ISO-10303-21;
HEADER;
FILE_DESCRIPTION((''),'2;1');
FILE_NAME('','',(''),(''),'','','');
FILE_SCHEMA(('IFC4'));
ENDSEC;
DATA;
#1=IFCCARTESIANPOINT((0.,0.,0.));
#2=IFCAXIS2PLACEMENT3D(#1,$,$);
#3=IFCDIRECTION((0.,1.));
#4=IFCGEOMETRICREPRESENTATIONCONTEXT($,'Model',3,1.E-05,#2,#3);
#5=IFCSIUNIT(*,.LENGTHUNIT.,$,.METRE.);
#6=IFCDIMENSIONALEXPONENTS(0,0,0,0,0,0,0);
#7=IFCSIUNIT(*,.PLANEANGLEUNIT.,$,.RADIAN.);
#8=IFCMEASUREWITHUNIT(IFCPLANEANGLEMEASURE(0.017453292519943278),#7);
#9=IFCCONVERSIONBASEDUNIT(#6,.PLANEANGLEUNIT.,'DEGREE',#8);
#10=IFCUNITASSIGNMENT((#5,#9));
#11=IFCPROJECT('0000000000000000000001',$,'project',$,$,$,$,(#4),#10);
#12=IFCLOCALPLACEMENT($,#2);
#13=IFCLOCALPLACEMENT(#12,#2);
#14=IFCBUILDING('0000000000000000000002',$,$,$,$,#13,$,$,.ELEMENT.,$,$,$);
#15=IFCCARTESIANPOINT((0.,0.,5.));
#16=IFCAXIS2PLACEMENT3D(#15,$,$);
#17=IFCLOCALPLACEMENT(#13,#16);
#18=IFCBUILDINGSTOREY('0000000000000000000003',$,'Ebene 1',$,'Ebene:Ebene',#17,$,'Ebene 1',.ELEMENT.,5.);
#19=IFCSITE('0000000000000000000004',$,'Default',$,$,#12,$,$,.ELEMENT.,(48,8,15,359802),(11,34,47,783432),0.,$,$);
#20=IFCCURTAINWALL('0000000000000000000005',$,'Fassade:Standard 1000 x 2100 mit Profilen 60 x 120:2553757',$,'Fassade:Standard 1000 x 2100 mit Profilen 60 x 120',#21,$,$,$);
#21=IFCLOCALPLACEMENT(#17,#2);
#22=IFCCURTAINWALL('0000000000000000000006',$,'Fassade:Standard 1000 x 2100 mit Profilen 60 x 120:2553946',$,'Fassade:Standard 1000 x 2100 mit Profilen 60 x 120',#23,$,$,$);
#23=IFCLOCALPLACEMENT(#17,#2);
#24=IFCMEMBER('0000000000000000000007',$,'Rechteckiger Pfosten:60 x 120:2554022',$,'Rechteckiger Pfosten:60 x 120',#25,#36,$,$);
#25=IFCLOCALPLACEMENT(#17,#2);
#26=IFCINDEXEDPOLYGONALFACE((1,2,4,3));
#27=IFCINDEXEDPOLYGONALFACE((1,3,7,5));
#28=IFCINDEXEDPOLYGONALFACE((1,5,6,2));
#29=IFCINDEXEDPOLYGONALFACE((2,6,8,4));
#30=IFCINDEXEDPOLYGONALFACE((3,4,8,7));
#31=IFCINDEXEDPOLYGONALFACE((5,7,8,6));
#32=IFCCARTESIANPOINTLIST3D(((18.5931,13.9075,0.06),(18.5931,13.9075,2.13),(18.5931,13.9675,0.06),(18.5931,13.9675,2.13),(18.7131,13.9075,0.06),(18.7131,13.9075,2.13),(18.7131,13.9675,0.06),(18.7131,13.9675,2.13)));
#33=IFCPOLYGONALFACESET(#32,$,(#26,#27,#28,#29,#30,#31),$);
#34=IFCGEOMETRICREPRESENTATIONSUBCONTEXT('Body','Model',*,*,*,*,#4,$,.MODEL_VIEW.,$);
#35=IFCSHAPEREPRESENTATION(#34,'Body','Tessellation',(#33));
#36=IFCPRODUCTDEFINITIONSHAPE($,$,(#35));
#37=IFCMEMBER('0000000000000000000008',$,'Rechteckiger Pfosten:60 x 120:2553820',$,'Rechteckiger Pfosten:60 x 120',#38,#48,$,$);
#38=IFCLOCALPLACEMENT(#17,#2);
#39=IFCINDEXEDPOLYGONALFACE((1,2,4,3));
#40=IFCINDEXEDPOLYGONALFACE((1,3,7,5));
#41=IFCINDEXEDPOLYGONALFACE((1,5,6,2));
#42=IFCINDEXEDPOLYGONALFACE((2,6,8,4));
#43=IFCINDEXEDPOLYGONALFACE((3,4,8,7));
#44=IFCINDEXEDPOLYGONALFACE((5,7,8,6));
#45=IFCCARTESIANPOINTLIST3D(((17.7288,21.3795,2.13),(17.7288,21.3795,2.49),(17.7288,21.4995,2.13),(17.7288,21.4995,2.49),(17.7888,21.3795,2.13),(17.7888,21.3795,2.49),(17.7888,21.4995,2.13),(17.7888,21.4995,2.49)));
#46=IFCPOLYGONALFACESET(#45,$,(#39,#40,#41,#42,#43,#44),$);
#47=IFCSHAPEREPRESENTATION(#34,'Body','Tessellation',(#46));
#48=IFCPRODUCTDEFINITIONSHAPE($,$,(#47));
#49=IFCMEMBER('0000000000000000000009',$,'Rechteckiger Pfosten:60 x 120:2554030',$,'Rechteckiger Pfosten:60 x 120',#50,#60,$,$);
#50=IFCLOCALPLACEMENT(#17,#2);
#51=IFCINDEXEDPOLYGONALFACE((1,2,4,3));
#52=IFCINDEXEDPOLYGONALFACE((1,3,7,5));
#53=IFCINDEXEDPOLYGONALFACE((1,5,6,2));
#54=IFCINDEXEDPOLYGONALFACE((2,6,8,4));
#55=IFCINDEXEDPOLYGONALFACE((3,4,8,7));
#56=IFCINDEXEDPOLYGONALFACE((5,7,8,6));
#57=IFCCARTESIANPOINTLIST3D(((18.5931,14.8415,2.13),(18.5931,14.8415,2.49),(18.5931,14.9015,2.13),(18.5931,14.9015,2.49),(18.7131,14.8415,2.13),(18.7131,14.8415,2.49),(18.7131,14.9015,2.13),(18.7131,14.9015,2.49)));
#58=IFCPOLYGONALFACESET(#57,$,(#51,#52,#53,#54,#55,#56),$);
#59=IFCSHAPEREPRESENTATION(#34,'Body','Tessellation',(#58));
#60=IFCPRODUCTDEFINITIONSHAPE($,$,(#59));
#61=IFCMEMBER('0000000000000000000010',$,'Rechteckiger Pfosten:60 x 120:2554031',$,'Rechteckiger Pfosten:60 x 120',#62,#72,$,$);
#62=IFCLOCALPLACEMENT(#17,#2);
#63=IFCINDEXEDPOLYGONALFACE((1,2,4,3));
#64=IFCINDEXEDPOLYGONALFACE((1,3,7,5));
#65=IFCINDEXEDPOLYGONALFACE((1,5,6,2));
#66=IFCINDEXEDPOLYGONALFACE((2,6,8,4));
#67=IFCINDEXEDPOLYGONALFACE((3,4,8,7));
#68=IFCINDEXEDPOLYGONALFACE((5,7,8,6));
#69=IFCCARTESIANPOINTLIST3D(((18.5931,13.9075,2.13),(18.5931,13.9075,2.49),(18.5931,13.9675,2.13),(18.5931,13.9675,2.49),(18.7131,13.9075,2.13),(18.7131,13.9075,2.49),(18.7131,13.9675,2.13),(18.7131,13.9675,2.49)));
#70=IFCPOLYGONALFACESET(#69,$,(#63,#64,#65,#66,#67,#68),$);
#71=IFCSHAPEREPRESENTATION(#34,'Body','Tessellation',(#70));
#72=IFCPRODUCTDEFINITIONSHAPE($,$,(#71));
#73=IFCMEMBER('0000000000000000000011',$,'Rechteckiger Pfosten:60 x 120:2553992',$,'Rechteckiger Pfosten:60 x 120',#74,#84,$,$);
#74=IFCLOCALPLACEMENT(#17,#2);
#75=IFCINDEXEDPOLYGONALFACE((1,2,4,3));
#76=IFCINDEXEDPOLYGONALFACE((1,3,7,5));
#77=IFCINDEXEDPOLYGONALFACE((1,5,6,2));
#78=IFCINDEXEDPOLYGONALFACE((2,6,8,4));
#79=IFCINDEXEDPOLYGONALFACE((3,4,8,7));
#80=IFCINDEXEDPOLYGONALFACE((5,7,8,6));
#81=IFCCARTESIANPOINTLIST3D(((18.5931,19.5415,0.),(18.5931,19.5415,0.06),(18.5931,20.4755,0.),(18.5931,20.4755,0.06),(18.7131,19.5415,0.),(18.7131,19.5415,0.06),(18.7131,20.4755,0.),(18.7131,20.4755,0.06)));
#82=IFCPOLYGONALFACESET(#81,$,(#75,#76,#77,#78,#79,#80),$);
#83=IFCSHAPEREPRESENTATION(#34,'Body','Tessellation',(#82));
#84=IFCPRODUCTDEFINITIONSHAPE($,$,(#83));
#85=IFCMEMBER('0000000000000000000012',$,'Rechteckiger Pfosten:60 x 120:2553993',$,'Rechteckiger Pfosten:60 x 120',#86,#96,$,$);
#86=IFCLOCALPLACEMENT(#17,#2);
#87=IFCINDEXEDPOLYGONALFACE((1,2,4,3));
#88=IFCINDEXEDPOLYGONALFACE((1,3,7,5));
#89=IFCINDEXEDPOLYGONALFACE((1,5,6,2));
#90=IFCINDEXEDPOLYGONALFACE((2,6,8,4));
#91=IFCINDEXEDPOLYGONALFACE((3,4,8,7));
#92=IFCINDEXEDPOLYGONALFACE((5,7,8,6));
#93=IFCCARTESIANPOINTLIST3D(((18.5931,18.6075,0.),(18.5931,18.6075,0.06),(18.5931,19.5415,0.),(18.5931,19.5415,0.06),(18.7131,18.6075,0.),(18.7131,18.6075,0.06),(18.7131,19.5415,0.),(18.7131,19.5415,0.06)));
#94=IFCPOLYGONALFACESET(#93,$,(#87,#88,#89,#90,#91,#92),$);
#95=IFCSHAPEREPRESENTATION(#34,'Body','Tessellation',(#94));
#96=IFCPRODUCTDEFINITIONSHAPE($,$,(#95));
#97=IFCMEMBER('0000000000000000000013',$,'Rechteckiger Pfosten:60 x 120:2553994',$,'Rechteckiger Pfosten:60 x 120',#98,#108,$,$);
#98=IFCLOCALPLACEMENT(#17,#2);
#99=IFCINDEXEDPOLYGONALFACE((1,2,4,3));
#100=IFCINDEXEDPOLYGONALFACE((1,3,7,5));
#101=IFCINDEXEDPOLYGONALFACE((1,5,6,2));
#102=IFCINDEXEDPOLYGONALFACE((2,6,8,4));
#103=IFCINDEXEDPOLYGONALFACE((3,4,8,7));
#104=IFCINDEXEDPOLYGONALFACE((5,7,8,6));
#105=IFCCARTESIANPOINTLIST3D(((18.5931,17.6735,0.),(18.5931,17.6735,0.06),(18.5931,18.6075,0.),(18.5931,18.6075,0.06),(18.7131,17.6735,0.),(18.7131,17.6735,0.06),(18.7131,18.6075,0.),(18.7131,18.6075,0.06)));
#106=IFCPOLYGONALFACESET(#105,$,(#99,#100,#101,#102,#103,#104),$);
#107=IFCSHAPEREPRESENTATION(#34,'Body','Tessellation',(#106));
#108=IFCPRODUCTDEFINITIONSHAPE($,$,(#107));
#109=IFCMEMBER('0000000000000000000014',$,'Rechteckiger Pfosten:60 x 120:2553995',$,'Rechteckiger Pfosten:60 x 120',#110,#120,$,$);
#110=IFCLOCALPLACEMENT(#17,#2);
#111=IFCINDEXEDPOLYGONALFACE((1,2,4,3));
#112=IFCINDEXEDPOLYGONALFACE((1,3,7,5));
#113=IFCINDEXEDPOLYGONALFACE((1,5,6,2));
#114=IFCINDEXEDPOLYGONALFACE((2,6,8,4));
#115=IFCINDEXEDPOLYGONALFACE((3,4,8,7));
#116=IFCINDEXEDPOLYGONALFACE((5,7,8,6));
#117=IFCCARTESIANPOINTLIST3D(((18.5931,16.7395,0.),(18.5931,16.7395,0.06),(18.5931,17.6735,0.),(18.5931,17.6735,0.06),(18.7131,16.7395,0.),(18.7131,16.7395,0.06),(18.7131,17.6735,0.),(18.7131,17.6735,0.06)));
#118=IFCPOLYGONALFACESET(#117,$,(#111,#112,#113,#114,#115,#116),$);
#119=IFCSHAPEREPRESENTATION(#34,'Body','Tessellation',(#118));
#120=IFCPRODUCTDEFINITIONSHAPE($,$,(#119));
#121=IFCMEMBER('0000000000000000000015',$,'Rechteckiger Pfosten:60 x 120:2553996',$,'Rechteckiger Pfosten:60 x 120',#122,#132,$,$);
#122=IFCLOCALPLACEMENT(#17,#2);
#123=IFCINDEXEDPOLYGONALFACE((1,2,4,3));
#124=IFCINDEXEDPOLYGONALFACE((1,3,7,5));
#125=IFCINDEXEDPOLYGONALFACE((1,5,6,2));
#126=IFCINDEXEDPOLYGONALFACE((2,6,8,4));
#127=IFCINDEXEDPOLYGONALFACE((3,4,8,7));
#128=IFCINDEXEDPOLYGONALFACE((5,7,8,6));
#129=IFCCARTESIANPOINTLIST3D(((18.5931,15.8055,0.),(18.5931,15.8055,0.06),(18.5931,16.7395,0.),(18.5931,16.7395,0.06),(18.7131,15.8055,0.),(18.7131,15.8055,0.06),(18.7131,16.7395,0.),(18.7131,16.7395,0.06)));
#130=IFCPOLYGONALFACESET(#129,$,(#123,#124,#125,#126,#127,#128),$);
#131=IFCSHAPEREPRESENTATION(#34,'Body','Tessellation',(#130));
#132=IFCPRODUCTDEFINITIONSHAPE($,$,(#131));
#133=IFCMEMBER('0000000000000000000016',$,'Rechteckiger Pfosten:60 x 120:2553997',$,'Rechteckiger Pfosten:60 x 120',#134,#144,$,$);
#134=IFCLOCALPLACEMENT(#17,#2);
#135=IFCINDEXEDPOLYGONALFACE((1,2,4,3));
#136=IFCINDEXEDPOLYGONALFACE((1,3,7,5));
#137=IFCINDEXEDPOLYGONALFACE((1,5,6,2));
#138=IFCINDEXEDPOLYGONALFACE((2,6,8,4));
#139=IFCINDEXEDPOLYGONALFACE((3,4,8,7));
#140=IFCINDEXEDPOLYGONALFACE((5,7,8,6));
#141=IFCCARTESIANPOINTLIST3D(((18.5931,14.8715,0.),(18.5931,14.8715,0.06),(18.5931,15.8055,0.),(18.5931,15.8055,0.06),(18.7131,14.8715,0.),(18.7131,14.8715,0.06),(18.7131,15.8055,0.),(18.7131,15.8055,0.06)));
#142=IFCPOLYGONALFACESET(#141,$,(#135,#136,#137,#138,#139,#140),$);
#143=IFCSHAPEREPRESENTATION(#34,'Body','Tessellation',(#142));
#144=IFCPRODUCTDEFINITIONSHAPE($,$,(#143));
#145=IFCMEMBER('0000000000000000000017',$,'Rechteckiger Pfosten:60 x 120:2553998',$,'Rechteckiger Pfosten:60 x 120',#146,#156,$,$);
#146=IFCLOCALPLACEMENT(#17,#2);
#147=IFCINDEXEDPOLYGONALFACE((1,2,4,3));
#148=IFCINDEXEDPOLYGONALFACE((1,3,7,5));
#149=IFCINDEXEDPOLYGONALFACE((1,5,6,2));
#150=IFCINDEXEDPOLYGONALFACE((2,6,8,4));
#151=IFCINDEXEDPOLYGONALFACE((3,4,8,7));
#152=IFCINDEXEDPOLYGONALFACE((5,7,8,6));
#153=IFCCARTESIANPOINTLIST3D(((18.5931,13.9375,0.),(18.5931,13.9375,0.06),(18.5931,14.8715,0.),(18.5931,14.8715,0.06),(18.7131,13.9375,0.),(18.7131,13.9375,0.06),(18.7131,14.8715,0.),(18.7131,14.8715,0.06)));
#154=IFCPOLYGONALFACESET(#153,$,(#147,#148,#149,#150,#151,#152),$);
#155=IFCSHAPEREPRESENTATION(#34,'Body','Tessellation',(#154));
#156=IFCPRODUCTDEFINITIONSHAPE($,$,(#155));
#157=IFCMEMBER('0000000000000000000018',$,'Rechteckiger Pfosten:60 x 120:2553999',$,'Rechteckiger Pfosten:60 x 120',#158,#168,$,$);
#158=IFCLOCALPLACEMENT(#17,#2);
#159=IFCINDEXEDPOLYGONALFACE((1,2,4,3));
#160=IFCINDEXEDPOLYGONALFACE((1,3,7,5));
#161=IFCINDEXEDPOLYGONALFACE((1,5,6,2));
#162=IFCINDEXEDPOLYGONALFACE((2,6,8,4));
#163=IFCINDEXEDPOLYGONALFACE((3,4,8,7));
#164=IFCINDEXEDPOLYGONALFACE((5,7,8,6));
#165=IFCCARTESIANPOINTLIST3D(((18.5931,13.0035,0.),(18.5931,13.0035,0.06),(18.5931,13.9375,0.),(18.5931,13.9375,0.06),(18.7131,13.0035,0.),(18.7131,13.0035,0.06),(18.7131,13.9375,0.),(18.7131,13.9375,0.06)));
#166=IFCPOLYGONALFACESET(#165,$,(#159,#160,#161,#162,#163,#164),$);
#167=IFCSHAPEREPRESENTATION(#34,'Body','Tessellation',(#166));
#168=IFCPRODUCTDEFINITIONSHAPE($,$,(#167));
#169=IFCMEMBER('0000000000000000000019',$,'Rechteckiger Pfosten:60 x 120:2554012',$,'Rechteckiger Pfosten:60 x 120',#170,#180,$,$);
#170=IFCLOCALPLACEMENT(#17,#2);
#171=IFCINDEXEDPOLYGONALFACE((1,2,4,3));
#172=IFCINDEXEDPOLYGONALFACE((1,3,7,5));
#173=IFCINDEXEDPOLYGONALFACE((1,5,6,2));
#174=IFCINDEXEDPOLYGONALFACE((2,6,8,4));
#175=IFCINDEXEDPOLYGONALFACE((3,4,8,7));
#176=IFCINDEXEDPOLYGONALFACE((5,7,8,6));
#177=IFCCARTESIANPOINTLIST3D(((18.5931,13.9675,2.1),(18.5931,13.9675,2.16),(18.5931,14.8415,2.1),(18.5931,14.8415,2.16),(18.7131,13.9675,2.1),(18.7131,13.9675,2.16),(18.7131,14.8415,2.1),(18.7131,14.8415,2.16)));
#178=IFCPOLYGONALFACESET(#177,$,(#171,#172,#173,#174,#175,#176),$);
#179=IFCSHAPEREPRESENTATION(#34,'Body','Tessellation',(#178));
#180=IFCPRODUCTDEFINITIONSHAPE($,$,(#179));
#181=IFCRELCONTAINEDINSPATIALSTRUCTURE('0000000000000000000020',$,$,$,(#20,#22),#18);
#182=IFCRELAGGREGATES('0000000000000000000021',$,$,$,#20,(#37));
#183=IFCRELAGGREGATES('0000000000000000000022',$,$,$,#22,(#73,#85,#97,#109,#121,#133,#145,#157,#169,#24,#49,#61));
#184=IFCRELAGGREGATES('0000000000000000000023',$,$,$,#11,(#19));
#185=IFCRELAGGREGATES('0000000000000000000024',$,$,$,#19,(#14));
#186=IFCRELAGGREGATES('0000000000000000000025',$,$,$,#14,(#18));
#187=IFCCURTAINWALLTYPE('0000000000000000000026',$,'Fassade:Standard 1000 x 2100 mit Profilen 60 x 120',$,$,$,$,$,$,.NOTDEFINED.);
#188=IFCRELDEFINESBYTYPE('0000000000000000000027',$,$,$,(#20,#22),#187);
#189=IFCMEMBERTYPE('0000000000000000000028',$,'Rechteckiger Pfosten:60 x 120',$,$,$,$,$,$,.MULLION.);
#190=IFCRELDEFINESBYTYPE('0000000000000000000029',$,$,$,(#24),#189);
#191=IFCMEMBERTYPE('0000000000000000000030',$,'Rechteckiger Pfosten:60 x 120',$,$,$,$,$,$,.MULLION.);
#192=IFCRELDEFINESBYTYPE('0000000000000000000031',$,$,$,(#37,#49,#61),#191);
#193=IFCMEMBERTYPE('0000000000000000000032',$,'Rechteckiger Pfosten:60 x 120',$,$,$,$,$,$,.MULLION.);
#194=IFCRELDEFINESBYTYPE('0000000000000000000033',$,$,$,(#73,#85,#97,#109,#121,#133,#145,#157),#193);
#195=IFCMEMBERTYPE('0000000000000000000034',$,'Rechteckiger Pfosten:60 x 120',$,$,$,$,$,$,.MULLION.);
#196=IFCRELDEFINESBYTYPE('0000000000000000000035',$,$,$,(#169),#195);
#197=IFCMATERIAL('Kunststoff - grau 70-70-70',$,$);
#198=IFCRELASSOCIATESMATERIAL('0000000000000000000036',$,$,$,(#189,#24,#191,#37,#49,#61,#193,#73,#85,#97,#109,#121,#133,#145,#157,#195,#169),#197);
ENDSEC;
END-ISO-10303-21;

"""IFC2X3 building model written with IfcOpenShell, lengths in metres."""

from ifc_helpers import new_model, entity, si_unit, converted_unit, direction, frame, frame_2d, origin, origin_2d_with_axis, place, context, subcontext, project, spatial, rectangle, extrude, source, transform, mapped, material, type_object, type_shapes, element, aggregate, save


model = new_model("IFC2X3")

# Units and contexts
model_context = context("Model", 3, precision=1e-05, world=origin(), true_north=direction((0.0, 1.0)))
body_context = subcontext(model_context, "Body", "Model", "MODEL_VIEW")
ifc_project = project(units=[si_unit("LENGTHUNIT", "METRE"), converted_unit("PLANEANGLEUNIT", "DEGREE", entity("IfcPlaneAngleMeasure", 0.017453292519943278), si_unit("PLANEANGLEUNIT", "RADIAN"), dimensions=[0, 0, 0, 0, 0, 0, 0])], contexts=[model_context])

# Site, building, storey
site_placement = place(None, origin())
site = spatial("IfcSite", under=ifc_project, at=site_placement, Name="Default", CompositionType="ELEMENT", RefLatitude=(48, 8, 15, 359802), RefLongitude=(11, 34, 47, 783432), RefElevation=0.0)
building_placement = place(site_placement, origin())
building = spatial("IfcBuilding", under=site, at=building_placement, CompositionType="ELEMENT")
storey_placement = place(building_placement, frame((0.0, 0.0, 5.0)))
storey = spatial("IfcBuildingStorey", under=building, at=storey_placement, Name="Ebene 1", ObjectType="Ebene:Ebene", LongName="Ebene 1", CompositionType="ELEMENT", Elevation=5.0)

# Curtain walls, member
curtain_wall_type = type_object("IfcCurtainWallType", Name="Fassade:Standard 1000 x 2100 mit Profilen 60 x 120", PredefinedType="NOTDEFINED")
curtain_wall_1_placement = place(storey_placement, frame((0.0, 0.0, -5.0)))
curtain_wall_1 = element("IfcCurtainWall", 1, at=curtain_wall_1_placement, inside=storey, type_object=curtain_wall_type, Name="Fassade:Standard 1000 x 2100 mit Profilen 60 x 120:2553757", ObjectType="Fassade:Standard 1000 x 2100 mit Profilen 60 x 120")
ifc_material_1 = material(Name="Kunststoff - grau 70-70-70")
member_type_1 = type_object("IfcMemberType", Name="Rechteckiger Pfosten:60 x 120", PredefinedType="MULLION", material=ifc_material_1)
shared_shape_1 = source(origin(), body_context, "Body", "SweptSolid", [
    extrude(rectangle(XDim=0.06, YDim=0.12, at=origin_2d_with_axis()), frame((0.0, 0.0, -2.07), z_axis=(0.0, 0.0, 1.0), x_axis=(-1.0, 0.0, 0.0)), (0.0, 0.0, 1.0), 2.07),
])
type_shapes(member_type_1, [shared_shape_1])
curtain_wall_2_placement = place(storey_placement, frame((0.0, 0.0, -5.0)))
curtain_wall_2 = element("IfcCurtainWall", 2, at=curtain_wall_2_placement, inside=storey, type_object=curtain_wall_type, Name="Fassade:Standard 1000 x 2100 mit Profilen 60 x 120:2553946", ObjectType="Fassade:Standard 1000 x 2100 mit Profilen 60 x 120")
member_1_placement = place(curtain_wall_2_placement, frame((18.6531, 13.9375, 5.06), z_axis=(0.0, 0.0, -1.0), x_axis=(0.0, -1.0, 0.0)))
member_1 = element("IfcMember", 3, at=member_1_placement, type_object=member_type_1, material=ifc_material_1, Name="Rechteckiger Pfosten:60 x 120:2554022", ObjectType="Rechteckiger Pfosten:60 x 120", context=body_context, shape_type="MappedRepresentation", body=[
    mapped(shared_shape_1, transform((0.0, 0.0, 0.0), scale=1.0)),
])

# Members
member_type_2 = type_object("IfcMemberType", Name="Rechteckiger Pfosten:60 x 120", PredefinedType="MULLION", material=ifc_material_1)
shared_shape_2 = source(origin(), body_context, "Body", "SweptSolid", [
    extrude(rectangle(XDim=0.06, YDim=0.12, at=frame_2d((0.0, 0.0), x_axis=(1.0, 0.0))), frame((0.0, 0.0, -0.36), z_axis=(0.0, 0.0, 1.0), x_axis=(-1.0, 0.0, 0.0)), (0.0, 0.0, 1.0), 0.36),
])
type_shapes(member_type_2, [shared_shape_2])
member_2_placement = place(curtain_wall_1_placement, frame((17.7588, 21.4395, 7.13), z_axis=(0.0, 0.0, -1.0), x_axis=(1.0, 0.0, 0.0)))
member_2 = element("IfcMember", 4, at=member_2_placement, type_object=member_type_2, material=ifc_material_1, Name="Rechteckiger Pfosten:60 x 120:2553820", ObjectType="Rechteckiger Pfosten:60 x 120", context=body_context, shape_type="MappedRepresentation", body=[
    mapped(shared_shape_2, transform((0.0, 0.0, 0.0), scale=1.0)),
])
member_3_placement = place(curtain_wall_2_placement, frame((18.6531, 14.8715, 7.13), z_axis=(0.0, 0.0, -1.0), x_axis=(0.0, -1.0, 0.0)))
member_3 = element("IfcMember", 5, at=member_3_placement, type_object=member_type_2, material=ifc_material_1, Name="Rechteckiger Pfosten:60 x 120:2554030", ObjectType="Rechteckiger Pfosten:60 x 120", context=body_context, shape_type="MappedRepresentation", body=[
    mapped(shared_shape_2, transform((0.0, 0.0, 0.0), scale=1.0)),
])
member_4_placement = place(curtain_wall_2_placement, frame((18.6531, 13.9375, 7.13), z_axis=(0.0, 0.0, -1.0), x_axis=(0.0, -1.0, 0.0)))
member_4 = element("IfcMember", 6, at=member_4_placement, type_object=member_type_2, material=ifc_material_1, Name="Rechteckiger Pfosten:60 x 120:2554031", ObjectType="Rechteckiger Pfosten:60 x 120", context=body_context, shape_type="MappedRepresentation", body=[
    mapped(shared_shape_2, transform((0.0, 0.0, 0.0), scale=1.0)),
])
member_type_3 = type_object("IfcMemberType", Name="Rechteckiger Pfosten:60 x 120", PredefinedType="MULLION", material=ifc_material_1)
shared_shape_3 = source(origin(), body_context, "Body", "SweptSolid", [
    extrude(rectangle(XDim=0.06, YDim=0.12, at=origin_2d_with_axis()), frame((-0.03, 0.0, -0.934), z_axis=(0.0, 0.0, 1.0), x_axis=(-1.0, 0.0, 0.0)), (0.0, 0.0, 1.0), 0.934),
])
type_shapes(member_type_3, [shared_shape_3])
member_5_placement = place(curtain_wall_2_placement, frame((18.6531, 20.4755, 5.0), z_axis=(0.0, 1.0, 0.0), x_axis=(0.0, 0.0, -1.0)))
member_5 = element("IfcMember", 7, at=member_5_placement, type_object=member_type_3, material=ifc_material_1, Name="Rechteckiger Pfosten:60 x 120:2553992", ObjectType="Rechteckiger Pfosten:60 x 120", context=body_context, shape_type="MappedRepresentation", body=[
    mapped(shared_shape_3, transform((0.0, 0.0, 0.0), scale=1.0)),
])
member_6_placement = place(curtain_wall_2_placement, frame((18.6531, 19.5415, 5.0), z_axis=(0.0, 1.0, 0.0), x_axis=(0.0, 0.0, -1.0)))
member_6 = element("IfcMember", 8, at=member_6_placement, type_object=member_type_3, material=ifc_material_1, Name="Rechteckiger Pfosten:60 x 120:2553993", ObjectType="Rechteckiger Pfosten:60 x 120", context=body_context, shape_type="MappedRepresentation", body=[
    mapped(shared_shape_3, transform((0.0, 0.0, 0.0), scale=1.0)),
])
member_7_placement = place(curtain_wall_2_placement, frame((18.6531, 18.6075, 5.0), z_axis=(0.0, 1.0, 0.0), x_axis=(0.0, 0.0, -1.0)))
member_7 = element("IfcMember", 9, at=member_7_placement, type_object=member_type_3, material=ifc_material_1, Name="Rechteckiger Pfosten:60 x 120:2553994", ObjectType="Rechteckiger Pfosten:60 x 120", context=body_context, shape_type="MappedRepresentation", body=[
    mapped(shared_shape_3, transform((0.0, 0.0, 0.0), scale=1.0)),
])
member_8_placement = place(curtain_wall_2_placement, frame((18.6531, 17.6735, 5.0), z_axis=(0.0, 1.0, 0.0), x_axis=(0.0, 0.0, -1.0)))
member_8 = element("IfcMember", 10, at=member_8_placement, type_object=member_type_3, material=ifc_material_1, Name="Rechteckiger Pfosten:60 x 120:2553995", ObjectType="Rechteckiger Pfosten:60 x 120", context=body_context, shape_type="MappedRepresentation", body=[
    mapped(shared_shape_3, transform((0.0, 0.0, 0.0), scale=1.0)),
])
member_9_placement = place(curtain_wall_2_placement, frame((18.6531, 16.7395, 5.0), z_axis=(0.0, 1.0, 0.0), x_axis=(0.0, 0.0, -1.0)))
member_9 = element("IfcMember", 11, at=member_9_placement, type_object=member_type_3, material=ifc_material_1, Name="Rechteckiger Pfosten:60 x 120:2553996", ObjectType="Rechteckiger Pfosten:60 x 120", context=body_context, shape_type="MappedRepresentation", body=[
    mapped(shared_shape_3, transform((0.0, 0.0, 0.0), scale=1.0)),
])
member_10_placement = place(curtain_wall_2_placement, frame((18.6531, 15.8055, 5.0), z_axis=(0.0, 1.0, 0.0), x_axis=(0.0, 0.0, -1.0)))
member_10 = element("IfcMember", 12, at=member_10_placement, type_object=member_type_3, material=ifc_material_1, Name="Rechteckiger Pfosten:60 x 120:2553997", ObjectType="Rechteckiger Pfosten:60 x 120", context=body_context, shape_type="MappedRepresentation", body=[
    mapped(shared_shape_3, transform((0.0, 0.0, 0.0), scale=1.0)),
])
member_11_placement = place(curtain_wall_2_placement, frame((18.6531, 14.8715, 5.0), z_axis=(0.0, 1.0, 0.0), x_axis=(0.0, 0.0, -1.0)))
member_11 = element("IfcMember", 13, at=member_11_placement, type_object=member_type_3, material=ifc_material_1, Name="Rechteckiger Pfosten:60 x 120:2553998", ObjectType="Rechteckiger Pfosten:60 x 120", context=body_context, shape_type="MappedRepresentation", body=[
    mapped(shared_shape_3, transform((0.0, 0.0, 0.0), scale=1.0)),
])
member_12_placement = place(curtain_wall_2_placement, frame((18.6531, 13.9375, 5.0), z_axis=(0.0, 1.0, 0.0), x_axis=(0.0, 0.0, -1.0)))
member_12 = element("IfcMember", 14, at=member_12_placement, type_object=member_type_3, material=ifc_material_1, Name="Rechteckiger Pfosten:60 x 120:2553999", ObjectType="Rechteckiger Pfosten:60 x 120", context=body_context, shape_type="MappedRepresentation", body=[
    mapped(shared_shape_3, transform((0.0, 0.0, 0.0), scale=1.0)),
])
member_type_4 = type_object("IfcMemberType", Name="Rechteckiger Pfosten:60 x 120", PredefinedType="MULLION", material=ifc_material_1)
shared_shape_4 = source(origin(), body_context, "Body", "SweptSolid", [
    extrude(rectangle(XDim=0.06, YDim=0.12, at=frame_2d((0.0, 0.0), x_axis=(1.0, 0.0))), frame((0.0, 0.0, -0.874), z_axis=(0.0, 0.0, 1.0), x_axis=(-1.0, 0.0, 0.0)), (0.0, 0.0, 1.0), 0.874),
])
type_shapes(member_type_4, [shared_shape_4])
member_13_placement = place(curtain_wall_2_placement, frame((18.6531, 13.9675, 7.13), z_axis=(0.0, -1.0, 0.0), x_axis=(0.0, 0.0, 1.0)))
member_13 = element("IfcMember", 15, at=member_13_placement, type_object=member_type_4, material=ifc_material_1, Name="Rechteckiger Pfosten:60 x 120:2554012", ObjectType="Rechteckiger Pfosten:60 x 120", context=body_context, shape_type="MappedRepresentation", body=[
    mapped(shared_shape_4, transform((0.0, 0.0, 0.0), scale=1.0)),
])

aggregate(curtain_wall_1, [member_2])
aggregate(curtain_wall_2, [member_5, member_6, member_7, member_8, member_9, member_10, member_11, member_12, member_13, member_1, member_3, member_4])

save(model, "model.ifc")
